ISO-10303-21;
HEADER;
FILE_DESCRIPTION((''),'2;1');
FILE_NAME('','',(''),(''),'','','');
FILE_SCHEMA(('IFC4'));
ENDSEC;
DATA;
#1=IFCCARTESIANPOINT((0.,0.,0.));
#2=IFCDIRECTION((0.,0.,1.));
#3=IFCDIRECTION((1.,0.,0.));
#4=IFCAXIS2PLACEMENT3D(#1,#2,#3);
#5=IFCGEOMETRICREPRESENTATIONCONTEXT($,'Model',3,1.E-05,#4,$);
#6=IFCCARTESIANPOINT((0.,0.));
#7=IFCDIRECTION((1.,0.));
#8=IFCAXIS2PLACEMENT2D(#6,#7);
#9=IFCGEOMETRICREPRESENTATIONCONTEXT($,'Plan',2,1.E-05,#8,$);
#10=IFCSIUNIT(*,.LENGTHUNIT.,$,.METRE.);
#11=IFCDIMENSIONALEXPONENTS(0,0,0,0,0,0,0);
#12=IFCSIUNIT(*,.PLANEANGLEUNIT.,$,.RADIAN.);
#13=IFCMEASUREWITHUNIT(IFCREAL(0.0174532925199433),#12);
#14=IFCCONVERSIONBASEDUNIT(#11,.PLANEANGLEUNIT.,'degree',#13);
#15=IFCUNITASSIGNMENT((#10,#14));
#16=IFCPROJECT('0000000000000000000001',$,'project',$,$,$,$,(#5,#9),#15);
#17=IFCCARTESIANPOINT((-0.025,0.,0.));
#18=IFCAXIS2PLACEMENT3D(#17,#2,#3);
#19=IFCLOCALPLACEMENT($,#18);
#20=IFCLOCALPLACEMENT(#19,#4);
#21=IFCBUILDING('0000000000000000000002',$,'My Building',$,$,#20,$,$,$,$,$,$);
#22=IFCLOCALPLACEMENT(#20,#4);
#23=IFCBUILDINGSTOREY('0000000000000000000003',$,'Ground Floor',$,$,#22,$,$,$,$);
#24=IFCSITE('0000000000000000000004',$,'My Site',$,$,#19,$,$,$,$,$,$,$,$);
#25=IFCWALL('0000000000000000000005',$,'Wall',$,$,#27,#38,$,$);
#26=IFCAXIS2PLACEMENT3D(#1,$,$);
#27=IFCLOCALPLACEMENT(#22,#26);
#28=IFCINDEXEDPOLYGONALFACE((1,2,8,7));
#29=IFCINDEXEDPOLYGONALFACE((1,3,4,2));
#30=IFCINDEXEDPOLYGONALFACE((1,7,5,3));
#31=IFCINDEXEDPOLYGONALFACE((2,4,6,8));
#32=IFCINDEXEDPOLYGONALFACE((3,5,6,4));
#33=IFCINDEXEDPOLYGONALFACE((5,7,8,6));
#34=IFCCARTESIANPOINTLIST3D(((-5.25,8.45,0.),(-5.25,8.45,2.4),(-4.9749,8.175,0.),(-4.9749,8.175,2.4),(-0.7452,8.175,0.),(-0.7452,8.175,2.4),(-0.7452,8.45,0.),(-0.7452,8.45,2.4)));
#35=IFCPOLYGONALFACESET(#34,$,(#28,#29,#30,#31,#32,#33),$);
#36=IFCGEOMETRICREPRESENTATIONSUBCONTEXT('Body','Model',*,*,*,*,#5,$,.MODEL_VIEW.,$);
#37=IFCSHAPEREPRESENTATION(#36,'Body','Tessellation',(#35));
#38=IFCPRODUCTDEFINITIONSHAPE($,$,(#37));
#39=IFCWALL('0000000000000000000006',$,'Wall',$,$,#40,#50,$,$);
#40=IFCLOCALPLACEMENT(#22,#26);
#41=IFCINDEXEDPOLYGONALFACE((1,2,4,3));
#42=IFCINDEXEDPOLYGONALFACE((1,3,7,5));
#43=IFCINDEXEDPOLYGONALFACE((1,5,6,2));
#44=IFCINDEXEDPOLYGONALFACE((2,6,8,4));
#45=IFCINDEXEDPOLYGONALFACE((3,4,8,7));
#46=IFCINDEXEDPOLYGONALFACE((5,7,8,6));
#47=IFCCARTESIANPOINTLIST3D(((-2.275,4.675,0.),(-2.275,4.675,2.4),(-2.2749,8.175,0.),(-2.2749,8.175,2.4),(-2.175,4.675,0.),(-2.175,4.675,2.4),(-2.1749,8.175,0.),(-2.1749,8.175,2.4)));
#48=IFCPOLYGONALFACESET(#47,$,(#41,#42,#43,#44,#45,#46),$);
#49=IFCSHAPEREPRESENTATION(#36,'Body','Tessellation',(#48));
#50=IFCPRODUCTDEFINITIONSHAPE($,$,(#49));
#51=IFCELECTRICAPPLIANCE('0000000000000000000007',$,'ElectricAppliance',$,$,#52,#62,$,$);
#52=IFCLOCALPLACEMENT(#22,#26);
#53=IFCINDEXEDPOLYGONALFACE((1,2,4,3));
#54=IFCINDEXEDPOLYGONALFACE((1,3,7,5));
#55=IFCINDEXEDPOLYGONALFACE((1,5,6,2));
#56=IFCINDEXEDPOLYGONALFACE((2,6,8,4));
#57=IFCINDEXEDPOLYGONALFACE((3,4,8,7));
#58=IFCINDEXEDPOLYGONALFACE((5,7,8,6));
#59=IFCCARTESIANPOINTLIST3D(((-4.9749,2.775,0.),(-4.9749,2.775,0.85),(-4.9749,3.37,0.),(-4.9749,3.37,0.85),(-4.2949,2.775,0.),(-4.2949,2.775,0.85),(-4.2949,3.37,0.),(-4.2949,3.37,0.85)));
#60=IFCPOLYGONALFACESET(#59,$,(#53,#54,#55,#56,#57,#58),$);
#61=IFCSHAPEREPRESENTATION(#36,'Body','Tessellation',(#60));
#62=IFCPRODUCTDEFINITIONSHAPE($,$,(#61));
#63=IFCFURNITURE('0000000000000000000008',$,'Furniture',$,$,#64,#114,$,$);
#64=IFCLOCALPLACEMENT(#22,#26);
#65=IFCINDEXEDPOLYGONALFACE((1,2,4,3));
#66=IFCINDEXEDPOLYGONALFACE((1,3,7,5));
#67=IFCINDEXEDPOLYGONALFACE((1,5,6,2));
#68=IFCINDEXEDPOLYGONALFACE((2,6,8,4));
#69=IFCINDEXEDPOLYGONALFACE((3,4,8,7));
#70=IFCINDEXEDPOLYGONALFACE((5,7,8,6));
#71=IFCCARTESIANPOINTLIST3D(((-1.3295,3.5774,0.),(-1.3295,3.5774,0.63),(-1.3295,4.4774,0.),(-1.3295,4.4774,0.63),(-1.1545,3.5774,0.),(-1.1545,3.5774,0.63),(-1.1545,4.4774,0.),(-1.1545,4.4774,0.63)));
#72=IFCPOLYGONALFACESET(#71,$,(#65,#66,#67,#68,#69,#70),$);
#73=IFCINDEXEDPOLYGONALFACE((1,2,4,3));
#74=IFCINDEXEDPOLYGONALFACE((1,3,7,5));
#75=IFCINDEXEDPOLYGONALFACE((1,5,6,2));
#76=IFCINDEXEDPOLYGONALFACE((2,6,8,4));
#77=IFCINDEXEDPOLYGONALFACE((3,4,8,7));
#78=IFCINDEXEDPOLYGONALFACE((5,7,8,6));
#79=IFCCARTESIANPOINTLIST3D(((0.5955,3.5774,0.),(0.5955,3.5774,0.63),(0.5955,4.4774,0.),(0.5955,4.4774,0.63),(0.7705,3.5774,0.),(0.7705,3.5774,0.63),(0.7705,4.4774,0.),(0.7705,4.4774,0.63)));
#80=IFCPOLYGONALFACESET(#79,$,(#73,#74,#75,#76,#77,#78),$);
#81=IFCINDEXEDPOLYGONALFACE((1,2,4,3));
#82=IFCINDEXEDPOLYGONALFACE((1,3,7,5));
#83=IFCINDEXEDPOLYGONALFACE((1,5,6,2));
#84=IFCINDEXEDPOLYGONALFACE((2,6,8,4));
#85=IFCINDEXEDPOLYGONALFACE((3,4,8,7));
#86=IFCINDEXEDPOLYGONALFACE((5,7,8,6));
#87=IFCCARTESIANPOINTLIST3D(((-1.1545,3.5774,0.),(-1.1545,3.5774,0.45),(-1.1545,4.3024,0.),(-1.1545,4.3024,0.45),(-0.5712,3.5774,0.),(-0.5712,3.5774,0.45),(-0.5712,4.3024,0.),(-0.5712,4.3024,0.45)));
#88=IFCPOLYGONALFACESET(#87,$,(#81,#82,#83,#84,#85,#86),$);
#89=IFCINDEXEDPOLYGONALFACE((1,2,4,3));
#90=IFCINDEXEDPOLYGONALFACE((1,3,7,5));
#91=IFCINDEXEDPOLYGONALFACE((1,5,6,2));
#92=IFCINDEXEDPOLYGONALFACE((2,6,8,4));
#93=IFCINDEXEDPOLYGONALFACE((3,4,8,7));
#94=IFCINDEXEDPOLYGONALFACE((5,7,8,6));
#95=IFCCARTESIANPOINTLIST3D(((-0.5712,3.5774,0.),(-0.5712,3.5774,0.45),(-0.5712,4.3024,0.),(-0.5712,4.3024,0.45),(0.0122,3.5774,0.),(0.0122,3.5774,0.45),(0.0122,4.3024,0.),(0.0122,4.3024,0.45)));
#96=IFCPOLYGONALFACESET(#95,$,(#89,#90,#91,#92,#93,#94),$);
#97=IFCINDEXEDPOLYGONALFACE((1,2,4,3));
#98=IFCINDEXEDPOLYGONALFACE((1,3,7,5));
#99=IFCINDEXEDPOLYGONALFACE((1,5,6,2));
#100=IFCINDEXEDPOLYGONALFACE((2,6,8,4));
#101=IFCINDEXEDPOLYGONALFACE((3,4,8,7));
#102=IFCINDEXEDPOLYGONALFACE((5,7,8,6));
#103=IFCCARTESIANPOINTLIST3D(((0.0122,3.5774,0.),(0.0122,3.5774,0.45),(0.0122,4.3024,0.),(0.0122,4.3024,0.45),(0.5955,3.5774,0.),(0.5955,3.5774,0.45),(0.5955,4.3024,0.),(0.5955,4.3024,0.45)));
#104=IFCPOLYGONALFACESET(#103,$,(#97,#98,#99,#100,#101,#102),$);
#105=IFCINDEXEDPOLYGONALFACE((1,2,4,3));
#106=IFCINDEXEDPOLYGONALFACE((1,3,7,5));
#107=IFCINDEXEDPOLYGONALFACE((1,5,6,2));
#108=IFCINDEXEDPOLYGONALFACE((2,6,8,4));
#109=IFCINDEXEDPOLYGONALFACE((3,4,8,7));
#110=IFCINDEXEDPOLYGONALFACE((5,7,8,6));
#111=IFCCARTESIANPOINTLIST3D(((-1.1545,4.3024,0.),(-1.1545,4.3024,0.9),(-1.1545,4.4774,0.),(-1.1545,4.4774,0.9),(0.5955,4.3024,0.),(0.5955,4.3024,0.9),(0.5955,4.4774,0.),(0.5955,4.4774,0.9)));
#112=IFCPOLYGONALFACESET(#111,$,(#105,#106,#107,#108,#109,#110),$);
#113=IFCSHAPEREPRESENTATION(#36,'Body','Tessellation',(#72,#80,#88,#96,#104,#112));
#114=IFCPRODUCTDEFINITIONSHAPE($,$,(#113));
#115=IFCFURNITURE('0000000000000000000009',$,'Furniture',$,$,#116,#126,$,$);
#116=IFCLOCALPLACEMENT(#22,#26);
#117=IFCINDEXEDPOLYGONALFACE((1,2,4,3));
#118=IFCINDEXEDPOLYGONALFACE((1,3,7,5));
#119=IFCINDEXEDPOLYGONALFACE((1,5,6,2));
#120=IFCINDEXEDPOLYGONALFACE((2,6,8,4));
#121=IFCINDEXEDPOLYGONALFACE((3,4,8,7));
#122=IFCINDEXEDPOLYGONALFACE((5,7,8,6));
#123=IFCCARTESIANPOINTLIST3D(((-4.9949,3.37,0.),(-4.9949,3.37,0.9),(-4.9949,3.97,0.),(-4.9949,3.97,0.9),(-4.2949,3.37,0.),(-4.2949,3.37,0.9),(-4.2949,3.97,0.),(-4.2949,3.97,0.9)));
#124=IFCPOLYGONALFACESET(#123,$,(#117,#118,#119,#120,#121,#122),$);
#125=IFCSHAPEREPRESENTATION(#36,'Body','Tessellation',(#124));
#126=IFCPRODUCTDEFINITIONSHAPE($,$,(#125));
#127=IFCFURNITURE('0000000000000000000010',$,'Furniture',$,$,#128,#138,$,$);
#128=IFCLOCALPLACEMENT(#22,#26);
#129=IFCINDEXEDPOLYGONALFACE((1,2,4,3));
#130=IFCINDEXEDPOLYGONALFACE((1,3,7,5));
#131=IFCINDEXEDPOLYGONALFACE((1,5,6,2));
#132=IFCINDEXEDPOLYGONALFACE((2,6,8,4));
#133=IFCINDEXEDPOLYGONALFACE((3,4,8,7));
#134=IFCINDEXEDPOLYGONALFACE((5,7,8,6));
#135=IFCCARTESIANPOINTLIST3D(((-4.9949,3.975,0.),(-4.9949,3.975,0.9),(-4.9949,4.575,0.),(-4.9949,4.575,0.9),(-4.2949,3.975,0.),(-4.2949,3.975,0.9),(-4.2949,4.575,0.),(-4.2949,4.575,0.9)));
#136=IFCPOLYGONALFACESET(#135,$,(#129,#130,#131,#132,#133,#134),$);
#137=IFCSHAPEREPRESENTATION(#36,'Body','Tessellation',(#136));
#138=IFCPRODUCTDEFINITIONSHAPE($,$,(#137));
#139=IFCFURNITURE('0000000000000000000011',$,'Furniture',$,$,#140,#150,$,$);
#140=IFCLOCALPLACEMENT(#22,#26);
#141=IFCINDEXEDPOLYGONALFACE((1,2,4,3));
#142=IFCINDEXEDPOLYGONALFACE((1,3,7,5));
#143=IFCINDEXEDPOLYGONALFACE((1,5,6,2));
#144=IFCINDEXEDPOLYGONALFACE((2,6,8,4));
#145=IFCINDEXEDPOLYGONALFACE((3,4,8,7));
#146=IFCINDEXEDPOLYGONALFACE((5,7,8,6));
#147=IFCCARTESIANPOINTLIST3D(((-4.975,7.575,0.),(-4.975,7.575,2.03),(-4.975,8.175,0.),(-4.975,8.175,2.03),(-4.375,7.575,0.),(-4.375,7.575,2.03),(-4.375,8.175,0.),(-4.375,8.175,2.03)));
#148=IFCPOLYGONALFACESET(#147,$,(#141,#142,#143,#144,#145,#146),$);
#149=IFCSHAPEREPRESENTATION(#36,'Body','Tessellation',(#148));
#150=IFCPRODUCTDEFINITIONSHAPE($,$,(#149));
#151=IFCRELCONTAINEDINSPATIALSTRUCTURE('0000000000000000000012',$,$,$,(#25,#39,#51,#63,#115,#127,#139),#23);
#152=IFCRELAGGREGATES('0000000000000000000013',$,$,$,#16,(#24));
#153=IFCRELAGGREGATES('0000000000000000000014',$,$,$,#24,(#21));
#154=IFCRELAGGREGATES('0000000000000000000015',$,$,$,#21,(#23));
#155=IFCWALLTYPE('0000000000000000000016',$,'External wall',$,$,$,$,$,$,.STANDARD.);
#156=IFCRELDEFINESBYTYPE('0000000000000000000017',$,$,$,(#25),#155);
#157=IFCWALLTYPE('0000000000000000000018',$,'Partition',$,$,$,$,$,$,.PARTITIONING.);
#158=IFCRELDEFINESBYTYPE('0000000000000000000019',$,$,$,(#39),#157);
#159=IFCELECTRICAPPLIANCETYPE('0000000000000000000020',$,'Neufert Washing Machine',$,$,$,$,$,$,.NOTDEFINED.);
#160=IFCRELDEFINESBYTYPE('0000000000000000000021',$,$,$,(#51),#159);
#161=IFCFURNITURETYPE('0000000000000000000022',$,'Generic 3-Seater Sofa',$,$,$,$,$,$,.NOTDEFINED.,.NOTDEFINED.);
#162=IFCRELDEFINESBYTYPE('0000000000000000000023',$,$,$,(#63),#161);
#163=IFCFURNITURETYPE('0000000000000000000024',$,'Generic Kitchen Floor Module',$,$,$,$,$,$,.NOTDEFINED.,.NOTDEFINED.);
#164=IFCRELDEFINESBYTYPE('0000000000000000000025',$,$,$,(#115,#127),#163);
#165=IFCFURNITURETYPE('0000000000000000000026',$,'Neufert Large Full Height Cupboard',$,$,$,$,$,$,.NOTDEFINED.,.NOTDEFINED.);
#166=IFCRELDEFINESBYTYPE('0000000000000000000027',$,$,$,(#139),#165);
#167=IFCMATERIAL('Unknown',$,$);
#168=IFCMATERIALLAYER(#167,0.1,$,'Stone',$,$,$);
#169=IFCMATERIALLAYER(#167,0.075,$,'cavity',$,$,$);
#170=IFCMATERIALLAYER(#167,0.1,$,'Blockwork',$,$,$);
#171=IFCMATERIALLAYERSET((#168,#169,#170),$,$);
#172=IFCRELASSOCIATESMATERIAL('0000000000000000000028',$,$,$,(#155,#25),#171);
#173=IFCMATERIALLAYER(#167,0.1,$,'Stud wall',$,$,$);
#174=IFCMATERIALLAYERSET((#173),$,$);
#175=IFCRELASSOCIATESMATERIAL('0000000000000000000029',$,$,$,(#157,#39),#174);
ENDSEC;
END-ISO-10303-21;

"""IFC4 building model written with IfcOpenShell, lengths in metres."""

from ifc_helpers import new_model, entity, si_unit, converted_unit, frame, origin_with_axes, origin_2d_with_axis, place, context, subcontext, project, spatial, line, indexed_curve, outline, extrude, clip, halfspace, shape, source, transform, mapped, material, layer, layer_set, layer_usage, type_object, type_shapes, element, save


model = new_model("IFC4")

# Units and contexts
model_context = context("Model", 3, precision=1e-05, world=origin_with_axes())
plan_context = context("Plan", 2, precision=1e-05, world=origin_2d_with_axis())
body_context_1 = subcontext(model_context, "Body", "Model", "MODEL_VIEW")
body_context_2 = subcontext(plan_context, "Body", "Plan", "PLAN_VIEW")
ifc_project = project(units=[si_unit("LENGTHUNIT", "METRE"), converted_unit("PLANEANGLEUNIT", "degree", entity("IfcReal", 0.0174532925199433), si_unit("PLANEANGLEUNIT", "RADIAN"), dimensions=[0, 0, 0, 0, 0, 0, 0])], contexts=[model_context, plan_context])

# Site, building, storey
site_placement = place(None, frame((-0.025, 0.0, 0.0), z_axis=(0.0, 0.0, 1.0), x_axis=(1.0, 0.0, 0.0)))
site = spatial("IfcSite", under=ifc_project, at=site_placement, Name="My Site")
building_placement = place(site_placement, origin_with_axes())
building = spatial("IfcBuilding", under=site, at=building_placement, Name="My Building")
storey_placement = place(building_placement, frame((0.0, 0.0, 0.0), z_axis=(0.0, 0.0, 1.0), x_axis=(1.0, 0.0, 0.0)))
storey = spatial("IfcBuildingStorey", under=building, at=storey_placement, Name="Ground Floor")

# Wall
ifc_material = material(Name="Unknown")
ifc_layer_1 = layer(ifc_material, 0.1, Name="Stone")
ifc_layer_2 = layer(ifc_material, 0.075, Name="cavity")
ifc_layer_3 = layer(ifc_material, 0.1, Name="Blockwork")
ifc_layer_set_1 = layer_set([ifc_layer_1, ifc_layer_2, ifc_layer_3])
ifc_layer_usage_1 = layer_usage(ifc_layer_set_1, "AXIS2", "POSITIVE", 0.0)
wall_type_1 = type_object("IfcWallType", Name="External wall", PredefinedType="STANDARD", material=ifc_layer_set_1)
wall_1_placement = place(storey_placement, frame((-0.7452, 8.45, 0.0), z_axis=(0.0, 0.0, 1.0), x_axis=(-1.0, 0.0, 0.0)))
element("IfcWall", 1, at=wall_1_placement, inside=storey, type_object=wall_type_1, material=ifc_layer_usage_1, Name="Wall", context=body_context_1, shape_type="Clipping", body=[
    clip(extrude(outline(indexed_curve([(0.0, 0.0), (0.0, 0.275), (4.5048, 0.275), (4.5048, 0.0), (0.0, 0.0)], self_intersect=False)), origin_with_axes(), (0.0, 0.0, 1.0), 2.4), halfspace(frame((4.5048, 0.0, 0.0), z_axis=(0.707106, 0.707107, 0.0), x_axis=(0.707107, -0.707106, 0.0)), False)),
])

# Shared definitions
ifc_layer_4 = layer(ifc_material, 0.1, Name="Stud wall")
ifc_layer_set_2 = layer_set([ifc_layer_4])
wall_type_2 = type_object("IfcWallType", Name="Partition", PredefinedType="PARTITIONING", material=ifc_layer_set_2)

# Wall
ifc_layer_usage_2 = layer_usage(ifc_layer_set_2, "AXIS2", "POSITIVE", 0.0)
wall_2_placement = place(storey_placement, frame((-2.175, 4.675, 0.0), z_axis=(0.0, 0.0, 1.0), x_axis=(0.0, 1.0, 0.0)))
element("IfcWall", 2, at=wall_2_placement, inside=storey, type_object=wall_type_2, material=ifc_layer_usage_2, Name="Wall", context=body_context_1, shape_type="SweptSolid", body=[
    extrude(outline(indexed_curve([(0.0, 0.0), (0.0, 0.1), (3.5, 0.1), (3.5, 0.0), (0.0, 0.0)], self_intersect=False)), origin_with_axes(), (0.0, 0.0, 1.0), 2.4),
])

# Electric appliance
electric_appliance_type_1 = type_object("IfcElectricApplianceType", Name="Neufert Washing Machine", PredefinedType="NOTDEFINED")
shared_shape_1 = source(origin_with_axes(), body_context_1, "Body", "SweptSolid", [
    extrude(outline(indexed_curve([(0.0, 0.0), (0.595, 0.0), (0.595, 0.68), (0.0, 0.68)], segments=[line(1, 2, 3, 4, 1)])), origin_with_axes(), (0.0, 0.0, 1.0), 0.85),
])
shared_shape_2 = source(origin_with_axes(), body_context_2, "Body", "Curve2D", [
    entity("IfcIndexedPolyCurve", entity("IfcCartesianPointList2D", [[0.0, 0.0], [0.595, 0.0], [0.595, 0.68], [0.0, 0.68]]), [entity("IfcLineIndex", [1, 2, 3, 4, 1])]),
    entity("IfcCircle", entity("IfcAxis2Placement2D", entity("IfcCartesianPoint", [0.2975, 0.34])), 0.1785),
    entity("IfcCircle", entity("IfcAxis2Placement2D", entity("IfcCartesianPoint", [0.2975, 0.34])), 0.0595),
])
type_shapes(electric_appliance_type_1, [shared_shape_1, shared_shape_2])
electric_appliance_1_placement = place(storey_placement, frame((-4.2949, 2.775, 0.0), z_axis=(0.0, 0.0, 1.0), x_axis=(0.0, 1.0, 0.0)))
element("IfcElectricAppliance", 3, at=electric_appliance_1_placement, inside=storey, type_object=electric_appliance_type_1, Name="ElectricAppliance", shapes=[
    shape(body_context_1, "Body", "MappedRepresentation", [mapped(shared_shape_1, transform((0.0, 0.0, 0.0), x_axis=(1.0, 0.0, 0.0), y_axis=(0.0, 1.0, 0.0), z_axis=(0.0, 0.0, 1.0), scale=1.0))]),
    shape(body_context_2, "Body", "MappedRepresentation", [mapped(shared_shape_2, transform((0.0, 0.0, 0.0), x_axis=(1.0, 0.0, 0.0), y_axis=(0.0, 1.0, 0.0), z_axis=(0.0, 0.0, 1.0), scale=1.0))]),
])

# Furniture
furniture_type_1 = type_object("IfcFurnitureType", Name="Generic 3-Seater Sofa", AssemblyPlace="NOTDEFINED", PredefinedType="NOTDEFINED")
shared_shape_3 = source(origin_with_axes(), body_context_1, "Body", "SweptSolid", [
    extrude(outline(indexed_curve([(0.0, 0.0), (0.175, 0.0), (0.175, 0.9), (0.0, 0.9)], segments=[line(1, 2, 3, 4, 1)])), frame((-1.05, -0.9, 0.0), z_axis=(0.0, 0.0, 1.0), x_axis=(1.0, 0.0, 0.0)), (0.0, 0.0, 1.0), 0.63),
    extrude(outline(indexed_curve([(0.0, 0.0), (0.175, 0.0), (0.175, 0.9), (0.0, 0.9)], segments=[line(1, 2, 3, 4, 1)])), frame((0.875, -0.9, 0.0), z_axis=(0.0, 0.0, 1.0), x_axis=(1.0, 0.0, 0.0)), (0.0, 0.0, 1.0), 0.63),
    extrude(outline(indexed_curve([(0.175, 0.0), (0.7583, 0.0), (0.7583, 0.725), (0.175, 0.725)], segments=[line(1, 2, 3, 4, 1)])), frame((-1.05, -0.9, 0.0), z_axis=(0.0, 0.0, 1.0), x_axis=(1.0, 0.0, 0.0)), (0.0, 0.0, 1.0), 0.45),
    extrude(outline(indexed_curve([(0.7583, 0.0), (1.3417, 0.0), (1.3417, 0.725), (0.7583, 0.725)], segments=[line(1, 2, 3, 4, 1)])), frame((-1.05, -0.9, 0.0), z_axis=(0.0, 0.0, 1.0), x_axis=(1.0, 0.0, 0.0)), (0.0, 0.0, 1.0), 0.45),
    extrude(outline(indexed_curve([(1.3417, 0.0), (1.925, 0.0), (1.925, 0.725), (1.3417, 0.725)], segments=[line(1, 2, 3, 4, 1)])), frame((-1.05, -0.9, 0.0), z_axis=(0.0, 0.0, 1.0), x_axis=(1.0, 0.0, 0.0)), (0.0, 0.0, 1.0), 0.45),
    extrude(outline(indexed_curve([(0.175, 0.725), (1.925, 0.725), (1.925, 0.9), (0.175, 0.9)], segments=[line(1, 2, 3, 4, 1)])), frame((-1.05, -0.9, 0.0), z_axis=(0.0, 0.0, 1.0), x_axis=(1.0, 0.0, 0.0)), (0.0, 0.0, 1.0), 0.9),
])
shared_shape_4 = source(origin_with_axes(), body_context_2, "Body", "Curve2D", [
    entity("IfcIndexedPolyCurve", entity("IfcCartesianPointList2D", [[-1.05, -0.9], [-0.875, -0.9], [-0.875, 0.0], [-1.05, 0.0]]), [entity("IfcLineIndex", [1, 2, 3, 4, 1])]),
    entity("IfcIndexedPolyCurve", entity("IfcCartesianPointList2D", [[0.875, -0.9], [1.05, -0.9], [1.05, 0.0], [0.875, 0.0]]), [entity("IfcLineIndex", [1, 2, 3, 4, 1])]),
    entity("IfcIndexedPolyCurve", entity("IfcCartesianPointList2D", [[-0.875, -0.9], [-0.2917, -0.9], [-0.2917, -0.175], [-0.875, -0.175]]), [entity("IfcLineIndex", [1, 2, 3, 4, 1])]),
    entity("IfcIndexedPolyCurve", entity("IfcCartesianPointList2D", [[-0.2917, -0.9], [0.2917, -0.9], [0.2917, -0.175], [-0.2917, -0.175]]), [entity("IfcLineIndex", [1, 2, 3, 4, 1])]),
    entity("IfcIndexedPolyCurve", entity("IfcCartesianPointList2D", [[0.2917, -0.9], [0.875, -0.9], [0.875, -0.175], [0.2917, -0.175]]), [entity("IfcLineIndex", [1, 2, 3, 4, 1])]),
    entity("IfcIndexedPolyCurve", entity("IfcCartesianPointList2D", [[-0.875, -0.175], [0.875, -0.175], [0.875, 0.0], [-0.875, 0.0]]), [entity("IfcLineIndex", [1, 2, 3, 4, 1])]),
])
type_shapes(furniture_type_1, [shared_shape_3, shared_shape_4])
furniture_1_placement = place(storey_placement, frame((-0.2795, 4.4774, 0.0), z_axis=(0.0, 0.0, 1.0), x_axis=(1.0, 0.0, 0.0)))
element("IfcFurniture", 4, at=furniture_1_placement, inside=storey, type_object=furniture_type_1, Name="Furniture", shapes=[
    shape(body_context_1, "Body", "MappedRepresentation", [mapped(shared_shape_3, transform((0.0, 0.0, 0.0), x_axis=(1.0, 0.0, 0.0), y_axis=(0.0, 1.0, 0.0), z_axis=(0.0, 0.0, 1.0), scale=1.0))]),
    shape(body_context_2, "Body", "MappedRepresentation", [mapped(shared_shape_4, transform((0.0, 0.0, 0.0), x_axis=(1.0, 0.0, 0.0), y_axis=(0.0, 1.0, 0.0), z_axis=(0.0, 0.0, 1.0), scale=1.0))]),
])
furniture_type_2 = type_object("IfcFurnitureType", Name="Generic Kitchen Floor Module", AssemblyPlace="NOTDEFINED", PredefinedType="NOTDEFINED")
shared_shape_5 = source(origin_with_axes(), body_context_1, "Body", "SweptSolid", [
    extrude(outline(indexed_curve([(0.0, 0.0), (0.6, 0.0), (0.6, 0.7), (0.0, 0.7)], segments=[line(1, 2, 3, 4, 1)])), origin_with_axes(), (0.0, 0.0, 1.0), 0.9),
])
shared_shape_6 = source(origin_with_axes(), body_context_2, "Body", "Curve2D", [
    entity("IfcIndexedPolyCurve", entity("IfcCartesianPointList2D", [[0.0, 0.0], [0.6, 0.0], [0.6, 0.7], [0.0, 0.7]]), [entity("IfcLineIndex", [1, 2, 3, 4, 1])]),
])
type_shapes(furniture_type_2, [shared_shape_5, shared_shape_6])
for number, where, z_axis, x_axis, name in (
    (5, (-4.2949, 3.37, 0.0), (0.0, 0.0, 1.0), (0.0, 1.0, 0.0), "Furniture"),
    (6, (-4.2949, 3.975, 0.0), (0.0, 0.0, 1.0), (0.0, 1.0, 0.0), "Furniture"),
):
    element("IfcFurniture", number, at=place(storey_placement, frame(where, z_axis=z_axis, x_axis=x_axis)), inside=storey, type_object=furniture_type_2, Name=name, shapes=[
        shape(body_context_1, "Body", "MappedRepresentation", [mapped(shared_shape_5, transform((0.0, 0.0, 0.0), x_axis=(1.0, 0.0, 0.0), y_axis=(0.0, 1.0, 0.0), z_axis=(0.0, 0.0, 1.0), scale=1.0))]),
        shape(body_context_2, "Body", "MappedRepresentation", [mapped(shared_shape_6, transform((0.0, 0.0, 0.0), x_axis=(1.0, 0.0, 0.0), y_axis=(0.0, 1.0, 0.0), z_axis=(0.0, 0.0, 1.0), scale=1.0))]),
    ])
furniture_type_3 = type_object("IfcFurnitureType", Name="Neufert Large Full Height Cupboard", AssemblyPlace="NOTDEFINED", PredefinedType="NOTDEFINED")
shared_shape_7 = source(origin_with_axes(), body_context_1, "Body", "SweptSolid", [
    extrude(outline(indexed_curve([(0.0, 0.0), (0.6, 0.0), (0.6, 0.6), (0.0, 0.6)], segments=[line(1, 2, 3, 4, 1)])), origin_with_axes(), (0.0, 0.0, 1.0), 2.03),
])
shared_shape_8 = source(origin_with_axes(), body_context_2, "Body", "Curve2D", [
    entity("IfcIndexedPolyCurve", entity("IfcCartesianPointList2D", [[0.0, 0.0], [0.6, 0.0], [0.6, 0.6], [0.0, 0.6]]), [entity("IfcLineIndex", [1, 2, 3, 4, 1])]),
])
type_shapes(furniture_type_3, [shared_shape_7, shared_shape_8])
furniture_2_placement = place(storey_placement, frame((-4.975, 7.575, 0.0), z_axis=(0.0, 0.0, 1.0), x_axis=(1.0, 0.0, 0.0)))
element("IfcFurniture", 7, at=furniture_2_placement, inside=storey, type_object=furniture_type_3, Name="Furniture", shapes=[
    shape(body_context_1, "Body", "MappedRepresentation", [mapped(shared_shape_7, transform((0.0, 0.0, 0.0), x_axis=(1.0, 0.0, 0.0), y_axis=(0.0, 1.0, 0.0), z_axis=(0.0, 0.0, 1.0), scale=1.0))]),
    shape(body_context_2, "Body", "MappedRepresentation", [mapped(shared_shape_8, transform((0.0, 0.0, 0.0), x_axis=(1.0, 0.0, 0.0), y_axis=(0.0, 1.0, 0.0), z_axis=(0.0, 0.0, 1.0), scale=1.0))]),
])

save(model, "model.ifc")
